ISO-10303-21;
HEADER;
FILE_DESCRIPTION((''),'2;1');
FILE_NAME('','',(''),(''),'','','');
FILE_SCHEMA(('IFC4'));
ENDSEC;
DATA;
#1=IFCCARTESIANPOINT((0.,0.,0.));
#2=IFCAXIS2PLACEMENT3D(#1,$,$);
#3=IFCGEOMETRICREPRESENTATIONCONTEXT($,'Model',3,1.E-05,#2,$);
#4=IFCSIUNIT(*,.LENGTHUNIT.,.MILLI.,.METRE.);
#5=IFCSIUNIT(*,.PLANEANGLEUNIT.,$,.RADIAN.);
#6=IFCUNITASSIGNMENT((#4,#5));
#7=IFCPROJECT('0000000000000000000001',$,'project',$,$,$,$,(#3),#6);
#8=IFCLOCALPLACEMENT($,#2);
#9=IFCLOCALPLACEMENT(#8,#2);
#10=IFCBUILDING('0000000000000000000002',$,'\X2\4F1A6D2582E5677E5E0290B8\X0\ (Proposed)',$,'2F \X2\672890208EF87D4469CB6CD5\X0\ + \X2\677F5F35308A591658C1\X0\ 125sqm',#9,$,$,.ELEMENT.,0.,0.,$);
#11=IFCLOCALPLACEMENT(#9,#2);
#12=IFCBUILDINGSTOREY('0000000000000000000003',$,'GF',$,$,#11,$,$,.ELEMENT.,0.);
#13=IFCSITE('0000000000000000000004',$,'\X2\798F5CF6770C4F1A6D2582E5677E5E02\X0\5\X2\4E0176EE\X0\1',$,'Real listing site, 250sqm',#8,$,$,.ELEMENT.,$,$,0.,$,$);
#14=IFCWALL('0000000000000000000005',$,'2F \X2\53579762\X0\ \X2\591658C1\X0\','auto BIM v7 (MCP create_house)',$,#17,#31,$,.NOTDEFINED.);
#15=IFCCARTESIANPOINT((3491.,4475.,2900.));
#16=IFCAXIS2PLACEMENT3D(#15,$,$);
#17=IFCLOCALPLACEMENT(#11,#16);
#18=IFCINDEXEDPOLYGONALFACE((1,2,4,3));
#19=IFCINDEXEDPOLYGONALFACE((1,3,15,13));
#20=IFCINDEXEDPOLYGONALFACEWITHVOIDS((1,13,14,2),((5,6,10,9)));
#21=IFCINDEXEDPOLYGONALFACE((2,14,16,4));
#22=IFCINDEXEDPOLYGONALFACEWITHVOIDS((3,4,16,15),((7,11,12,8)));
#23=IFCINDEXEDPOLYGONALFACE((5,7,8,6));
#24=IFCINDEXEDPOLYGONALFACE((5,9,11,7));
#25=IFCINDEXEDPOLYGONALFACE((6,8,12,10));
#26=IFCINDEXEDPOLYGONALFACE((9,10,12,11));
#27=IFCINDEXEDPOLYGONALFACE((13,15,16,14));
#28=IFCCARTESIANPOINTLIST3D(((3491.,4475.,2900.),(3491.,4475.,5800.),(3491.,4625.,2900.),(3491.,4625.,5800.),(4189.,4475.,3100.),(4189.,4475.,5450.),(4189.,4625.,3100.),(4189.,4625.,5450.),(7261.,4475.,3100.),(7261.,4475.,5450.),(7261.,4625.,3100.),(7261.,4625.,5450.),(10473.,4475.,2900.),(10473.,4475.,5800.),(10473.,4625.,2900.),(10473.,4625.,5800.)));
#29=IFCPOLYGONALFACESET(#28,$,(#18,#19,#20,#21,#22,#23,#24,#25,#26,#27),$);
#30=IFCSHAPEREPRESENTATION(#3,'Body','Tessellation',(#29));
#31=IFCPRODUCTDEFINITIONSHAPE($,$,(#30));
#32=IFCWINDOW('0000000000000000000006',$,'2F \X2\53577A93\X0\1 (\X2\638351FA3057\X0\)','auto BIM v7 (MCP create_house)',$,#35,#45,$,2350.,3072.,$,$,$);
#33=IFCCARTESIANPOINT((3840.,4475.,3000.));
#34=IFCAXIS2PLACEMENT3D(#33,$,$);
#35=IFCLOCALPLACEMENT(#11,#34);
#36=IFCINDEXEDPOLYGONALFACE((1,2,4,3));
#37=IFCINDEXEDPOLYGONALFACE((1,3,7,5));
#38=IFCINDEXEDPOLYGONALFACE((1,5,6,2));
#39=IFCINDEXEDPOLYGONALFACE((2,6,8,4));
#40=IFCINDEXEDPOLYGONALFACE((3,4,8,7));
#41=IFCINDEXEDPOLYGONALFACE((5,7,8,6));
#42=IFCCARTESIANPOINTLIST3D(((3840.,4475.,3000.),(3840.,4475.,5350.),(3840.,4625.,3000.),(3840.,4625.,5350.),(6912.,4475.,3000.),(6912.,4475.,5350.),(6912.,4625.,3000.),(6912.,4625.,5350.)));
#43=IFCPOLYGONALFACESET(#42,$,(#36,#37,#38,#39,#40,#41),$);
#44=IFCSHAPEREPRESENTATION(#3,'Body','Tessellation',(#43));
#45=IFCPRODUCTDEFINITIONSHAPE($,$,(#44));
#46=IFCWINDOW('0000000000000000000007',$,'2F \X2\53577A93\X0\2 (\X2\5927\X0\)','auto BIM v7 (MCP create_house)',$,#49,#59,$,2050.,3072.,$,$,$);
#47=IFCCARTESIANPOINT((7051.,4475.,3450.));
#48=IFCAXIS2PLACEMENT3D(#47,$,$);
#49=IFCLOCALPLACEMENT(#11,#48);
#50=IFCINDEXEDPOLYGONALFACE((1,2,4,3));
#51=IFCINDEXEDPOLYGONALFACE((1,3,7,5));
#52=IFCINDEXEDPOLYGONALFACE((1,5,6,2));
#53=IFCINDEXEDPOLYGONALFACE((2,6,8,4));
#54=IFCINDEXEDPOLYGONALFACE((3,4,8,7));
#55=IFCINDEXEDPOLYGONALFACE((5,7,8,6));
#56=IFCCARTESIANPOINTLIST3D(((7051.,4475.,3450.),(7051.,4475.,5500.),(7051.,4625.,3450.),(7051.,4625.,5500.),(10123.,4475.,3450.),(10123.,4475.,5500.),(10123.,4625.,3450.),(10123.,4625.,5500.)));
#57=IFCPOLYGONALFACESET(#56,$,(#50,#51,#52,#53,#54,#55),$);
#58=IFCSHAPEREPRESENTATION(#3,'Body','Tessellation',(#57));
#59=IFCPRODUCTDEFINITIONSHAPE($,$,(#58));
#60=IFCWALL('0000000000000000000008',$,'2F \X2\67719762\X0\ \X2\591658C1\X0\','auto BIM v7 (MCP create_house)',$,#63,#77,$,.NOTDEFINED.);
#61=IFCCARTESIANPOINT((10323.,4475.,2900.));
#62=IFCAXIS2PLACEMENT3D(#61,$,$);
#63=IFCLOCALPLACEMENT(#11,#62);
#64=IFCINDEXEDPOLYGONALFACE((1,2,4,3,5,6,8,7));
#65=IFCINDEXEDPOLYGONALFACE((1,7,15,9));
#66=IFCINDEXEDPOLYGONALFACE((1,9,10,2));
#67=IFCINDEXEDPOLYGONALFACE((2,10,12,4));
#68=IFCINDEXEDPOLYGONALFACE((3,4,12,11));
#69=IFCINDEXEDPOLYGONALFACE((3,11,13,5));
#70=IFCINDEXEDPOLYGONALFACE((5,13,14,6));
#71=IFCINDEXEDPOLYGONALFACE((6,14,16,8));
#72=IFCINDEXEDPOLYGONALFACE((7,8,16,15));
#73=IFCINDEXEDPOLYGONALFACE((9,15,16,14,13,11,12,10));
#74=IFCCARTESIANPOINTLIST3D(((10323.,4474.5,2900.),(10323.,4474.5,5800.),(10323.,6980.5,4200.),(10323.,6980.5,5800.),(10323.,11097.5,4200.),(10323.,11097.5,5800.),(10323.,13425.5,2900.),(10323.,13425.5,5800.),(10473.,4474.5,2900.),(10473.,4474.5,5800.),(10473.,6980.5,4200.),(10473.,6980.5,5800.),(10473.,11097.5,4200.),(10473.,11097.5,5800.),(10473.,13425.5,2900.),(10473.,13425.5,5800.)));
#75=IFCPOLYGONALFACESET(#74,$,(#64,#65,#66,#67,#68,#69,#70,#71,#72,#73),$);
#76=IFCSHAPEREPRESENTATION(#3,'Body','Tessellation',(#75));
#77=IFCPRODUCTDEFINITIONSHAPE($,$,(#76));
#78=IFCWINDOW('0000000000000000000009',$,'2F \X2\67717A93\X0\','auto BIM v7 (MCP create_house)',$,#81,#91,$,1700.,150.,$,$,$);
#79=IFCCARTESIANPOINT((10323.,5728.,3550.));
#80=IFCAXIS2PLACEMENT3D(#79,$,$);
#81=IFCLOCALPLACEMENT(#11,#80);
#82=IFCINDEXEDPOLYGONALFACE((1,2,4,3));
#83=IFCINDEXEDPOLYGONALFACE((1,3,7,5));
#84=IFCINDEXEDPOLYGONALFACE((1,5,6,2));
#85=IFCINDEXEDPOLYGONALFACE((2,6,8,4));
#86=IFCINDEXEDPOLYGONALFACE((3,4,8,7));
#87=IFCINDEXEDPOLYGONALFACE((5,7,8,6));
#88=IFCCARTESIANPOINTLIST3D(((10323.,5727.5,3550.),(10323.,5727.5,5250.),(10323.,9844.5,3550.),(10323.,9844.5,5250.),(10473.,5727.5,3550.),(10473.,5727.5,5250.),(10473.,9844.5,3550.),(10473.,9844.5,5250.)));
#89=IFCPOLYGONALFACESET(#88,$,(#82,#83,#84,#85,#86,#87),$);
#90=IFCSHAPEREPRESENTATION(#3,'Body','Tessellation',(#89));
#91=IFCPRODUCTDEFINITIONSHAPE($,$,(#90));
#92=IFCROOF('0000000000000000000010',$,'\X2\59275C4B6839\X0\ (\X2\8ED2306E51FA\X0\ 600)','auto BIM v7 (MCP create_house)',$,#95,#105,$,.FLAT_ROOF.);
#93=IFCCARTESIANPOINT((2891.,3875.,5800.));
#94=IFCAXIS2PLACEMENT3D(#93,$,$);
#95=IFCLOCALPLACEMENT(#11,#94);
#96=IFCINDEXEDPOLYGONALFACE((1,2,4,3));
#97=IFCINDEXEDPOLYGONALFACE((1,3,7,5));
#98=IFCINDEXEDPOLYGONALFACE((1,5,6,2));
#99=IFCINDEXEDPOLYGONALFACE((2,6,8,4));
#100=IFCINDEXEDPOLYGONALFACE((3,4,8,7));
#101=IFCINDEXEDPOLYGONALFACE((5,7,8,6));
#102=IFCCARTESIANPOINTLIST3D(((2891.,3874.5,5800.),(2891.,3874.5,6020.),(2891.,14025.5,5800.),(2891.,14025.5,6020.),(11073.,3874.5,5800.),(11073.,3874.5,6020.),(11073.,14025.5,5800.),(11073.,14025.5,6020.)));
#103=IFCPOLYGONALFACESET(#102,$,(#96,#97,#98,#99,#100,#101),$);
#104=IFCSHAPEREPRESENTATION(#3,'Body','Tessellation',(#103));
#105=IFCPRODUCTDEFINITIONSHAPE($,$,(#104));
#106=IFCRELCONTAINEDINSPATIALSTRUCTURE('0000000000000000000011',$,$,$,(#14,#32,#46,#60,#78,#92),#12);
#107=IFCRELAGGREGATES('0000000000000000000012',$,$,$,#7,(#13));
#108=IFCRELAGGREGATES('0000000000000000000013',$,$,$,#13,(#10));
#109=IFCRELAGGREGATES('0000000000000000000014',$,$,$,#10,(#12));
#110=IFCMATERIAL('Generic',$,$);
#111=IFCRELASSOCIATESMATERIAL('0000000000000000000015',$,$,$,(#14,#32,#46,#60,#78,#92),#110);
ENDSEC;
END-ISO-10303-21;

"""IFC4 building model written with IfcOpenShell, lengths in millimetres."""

from ifc_helpers import new_model, si_unit, frame, frame_2d, origin, place, context, project, spatial, rectangle, extrude, material, element, fill, save


model = new_model("IFC4")

# Units and contexts
model_context = context("Model", 3, precision=1e-05, world=origin())
ifc_project = project(units=[si_unit("LENGTHUNIT", "METRE", prefix="MILLI"), si_unit("PLANEANGLEUNIT", "RADIAN")], contexts=[model_context])

# Site, building, storey
site_placement = place(None, origin())
site = spatial("IfcSite", under=ifc_project, at=site_placement, Name="福島県会津若松市5丁目1", ObjectType="Real listing site, 250sqm", CompositionType="ELEMENT", RefElevation=0.0)
building_placement = place(site_placement, origin())
building = spatial("IfcBuilding", under=site, at=building_placement, Name="会津若松市邸 (Proposed)", ObjectType="2F 木造軸組構法 + 板張り外壁 125sqm", CompositionType="ELEMENT", ElevationOfRefHeight=0.0, ElevationOfTerrain=0.0)
storey_placement = place(building_placement, origin())
storey = spatial("IfcBuildingStorey", under=building, at=storey_placement, Name="GF", CompositionType="ELEMENT", Elevation=0.0)

# Shared definitions
ifc_material = material(Name="Generic")

# Wall, openings, windows
wall_1_placement = place(storey_placement, frame((3491.0, 4475.0, 2900.0)))
wall_1 = element("IfcWall", 1, at=wall_1_placement, inside=storey, material=ifc_material, Name="2F 南面 外壁", Description="auto BIM v7 (MCP create_house)", PredefinedType="NOTDEFINED", context=model_context, shape_type="SweptSolid", body=[
    extrude(rectangle(XDim=6982.0, YDim=150.0, at=frame_2d((3491.0, 75.0))), frame((3491.0, 4475.0, 2900.0)), (0.0, 0.0, 1.0), 2900.0),
])
opening_1_placement = place(storey_placement, frame((3840.0, 4475.0, 3000.0)))
opening_1 = element("IfcOpeningElement", 2, at=opening_1_placement, cuts=wall_1, PredefinedType="NOTDEFINED", context=model_context, shape_type="SweptSolid", body=[
    extrude(rectangle(XDim=3072.0, YDim=150.0, at=frame_2d((1536.0, 75.0))), frame((3840.0, 4475.0, 3000.0)), (0.0, 0.0, 1.0), 2350.0),
])
opening_2_placement = place(storey_placement, frame((7051.0, 4475.0, 3450.0)))
opening_2 = element("IfcOpeningElement", 3, at=opening_2_placement, cuts=wall_1, PredefinedType="NOTDEFINED", context=model_context, shape_type="SweptSolid", body=[
    extrude(rectangle(XDim=3072.0, YDim=150.0, at=frame_2d((1536.0, 75.0))), frame((7051.0, 4475.0, 3450.0)), (0.0, 0.0, 1.0), 2050.0),
])
window_1_placement = place(storey_placement, frame((3840.0, 4475.0, 3000.0)))
window_1 = element("IfcWindow", 4, at=window_1_placement, inside=storey, material=ifc_material, Name="2F 南窓1 (掃出し)", Description="auto BIM v7 (MCP create_house)", OverallHeight=2350.0, OverallWidth=3072.0, context=model_context, shape_type="SweptSolid", body=[
    extrude(rectangle(XDim=3072.0, YDim=150.0, at=frame_2d((1536.0, 75.0))), frame((3840.0, 4475.0, 3000.0)), (0.0, 0.0, 1.0), 2350.0),
])
fill(opening_1, window_1)
window_2_placement = place(storey_placement, frame((7051.0, 4475.0, 3450.0)))
window_2 = element("IfcWindow", 5, at=window_2_placement, inside=storey, material=ifc_material, Name="2F 南窓2 (大)", Description="auto BIM v7 (MCP create_house)", OverallHeight=2050.0, OverallWidth=3072.0, context=model_context, shape_type="SweptSolid", body=[
    extrude(rectangle(XDim=3072.0, YDim=150.0, at=frame_2d((1536.0, 75.0))), frame((7051.0, 4475.0, 3450.0)), (0.0, 0.0, 1.0), 2050.0),
])
fill(opening_2, window_2)

# Wall, opening, window
wall_2_placement = place(storey_placement, frame((10323.0, 4475.0, 2900.0)))
wall_2 = element("IfcWall", 6, at=wall_2_placement, inside=storey, material=ifc_material, Name="2F 東面 外壁", Description="auto BIM v7 (MCP create_house)", PredefinedType="NOTDEFINED", context=model_context, shape_type="SweptSolid", body=[
    extrude(rectangle(XDim=150.0, YDim=8951.0, at=frame_2d((75.0, 4475.0))), frame((10323.0, 4475.0, 2900.0)), (0.0, 0.0, 1.0), 2900.0),
])
opening_3_placement = place(storey_placement, frame((10323.0, 5728.0, 3550.0)))
opening_3 = element("IfcOpeningElement", 7, at=opening_3_placement, cuts=wall_2, PredefinedType="NOTDEFINED", context=model_context, shape_type="SweptSolid", body=[
    extrude(rectangle(XDim=150.0, YDim=4117.0, at=frame_2d((75.0, 2058.0))), frame((10323.0, 5728.0, 3550.0)), (0.0, 0.0, 1.0), 1700.0),
])
window_3_placement = place(storey_placement, frame((10323.0, 5728.0, 3550.0)))
window_3 = element("IfcWindow", 8, at=window_3_placement, inside=storey, material=ifc_material, Name="2F 東窓", Description="auto BIM v7 (MCP create_house)", OverallHeight=1700.0, OverallWidth=150.0, context=model_context, shape_type="SweptSolid", body=[
    extrude(rectangle(XDim=150.0, YDim=4117.0, at=frame_2d((75.0, 2058.0))), frame((10323.0, 5728.0, 3550.0)), (0.0, 0.0, 1.0), 1700.0),
])
fill(opening_3, window_3)

# Roof
roof_placement = place(storey_placement, frame((2891.0, 3875.0, 5800.0)))
element("IfcRoof", 9, at=roof_placement, inside=storey, material=ifc_material, Name="大屋根 (軒の出 600)", Description="auto BIM v7 (MCP create_house)", PredefinedType="FLAT_ROOF", context=model_context, shape_type="SweptSolid", body=[
    extrude(rectangle(XDim=8182.0, YDim=10151.0, at=frame_2d((4091.0, 5075.0))), frame((2891.0, 3875.0, 5800.0)), (0.0, 0.0, 1.0), 220.0),
])

save(model, "model.ifc")
